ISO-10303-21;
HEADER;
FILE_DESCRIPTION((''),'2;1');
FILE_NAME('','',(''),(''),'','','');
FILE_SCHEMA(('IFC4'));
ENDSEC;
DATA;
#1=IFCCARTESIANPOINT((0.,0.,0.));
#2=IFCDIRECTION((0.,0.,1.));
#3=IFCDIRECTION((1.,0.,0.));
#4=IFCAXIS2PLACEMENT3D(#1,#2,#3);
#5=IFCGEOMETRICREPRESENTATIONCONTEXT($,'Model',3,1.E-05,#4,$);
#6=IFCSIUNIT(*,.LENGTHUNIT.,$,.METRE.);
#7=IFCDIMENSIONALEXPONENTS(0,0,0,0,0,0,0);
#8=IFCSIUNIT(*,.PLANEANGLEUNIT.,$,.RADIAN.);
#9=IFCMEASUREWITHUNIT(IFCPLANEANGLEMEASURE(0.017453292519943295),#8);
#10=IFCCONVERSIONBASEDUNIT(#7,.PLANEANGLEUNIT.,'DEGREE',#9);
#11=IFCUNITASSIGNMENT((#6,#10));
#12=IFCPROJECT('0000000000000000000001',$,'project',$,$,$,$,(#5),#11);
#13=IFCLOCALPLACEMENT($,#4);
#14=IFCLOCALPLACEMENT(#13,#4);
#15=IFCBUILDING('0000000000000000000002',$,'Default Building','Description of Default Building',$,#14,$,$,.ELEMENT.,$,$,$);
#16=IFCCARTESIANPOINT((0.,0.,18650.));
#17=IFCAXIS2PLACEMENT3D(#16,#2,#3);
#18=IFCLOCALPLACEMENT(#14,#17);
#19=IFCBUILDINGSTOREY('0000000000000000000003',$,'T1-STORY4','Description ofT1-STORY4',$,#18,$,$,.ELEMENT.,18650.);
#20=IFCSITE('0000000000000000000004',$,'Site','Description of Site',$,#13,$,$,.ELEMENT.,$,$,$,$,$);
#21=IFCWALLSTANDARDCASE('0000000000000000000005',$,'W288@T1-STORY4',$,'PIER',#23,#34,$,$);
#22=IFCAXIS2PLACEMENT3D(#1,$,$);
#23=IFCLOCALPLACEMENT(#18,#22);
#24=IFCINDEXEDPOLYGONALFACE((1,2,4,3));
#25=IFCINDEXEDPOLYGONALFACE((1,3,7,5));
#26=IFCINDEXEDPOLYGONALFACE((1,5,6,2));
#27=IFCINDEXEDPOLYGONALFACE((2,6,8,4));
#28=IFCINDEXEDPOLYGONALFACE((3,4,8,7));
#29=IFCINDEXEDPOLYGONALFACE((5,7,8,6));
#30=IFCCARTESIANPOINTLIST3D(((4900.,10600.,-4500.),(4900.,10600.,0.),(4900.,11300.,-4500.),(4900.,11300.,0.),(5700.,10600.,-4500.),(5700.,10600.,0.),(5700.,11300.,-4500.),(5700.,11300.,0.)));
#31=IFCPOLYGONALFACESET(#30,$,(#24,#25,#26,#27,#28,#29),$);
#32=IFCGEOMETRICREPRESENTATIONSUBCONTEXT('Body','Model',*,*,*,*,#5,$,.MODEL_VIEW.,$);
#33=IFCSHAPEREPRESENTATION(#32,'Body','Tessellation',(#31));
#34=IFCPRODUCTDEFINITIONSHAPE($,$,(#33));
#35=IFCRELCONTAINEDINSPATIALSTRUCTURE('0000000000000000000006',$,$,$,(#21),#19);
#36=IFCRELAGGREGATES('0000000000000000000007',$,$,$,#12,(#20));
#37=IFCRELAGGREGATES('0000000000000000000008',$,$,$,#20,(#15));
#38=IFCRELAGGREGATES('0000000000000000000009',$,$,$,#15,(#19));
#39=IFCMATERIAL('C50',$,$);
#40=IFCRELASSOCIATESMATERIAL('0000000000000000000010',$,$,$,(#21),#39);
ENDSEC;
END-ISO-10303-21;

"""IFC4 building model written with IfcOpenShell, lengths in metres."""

from ifc_helpers import new_model, entity, si_unit, converted_unit, frame, origin_with_axes, place, context, subcontext, project, spatial, indexed_curve, outline, extrude, material, element, save


model = new_model("IFC4")

# Units and contexts
model_context = context("Model", 3, precision=1e-05, world=origin_with_axes())
body_context = subcontext(model_context, "Body", "Model", "MODEL_VIEW")
ifc_project = project(units=[si_unit("LENGTHUNIT", "METRE"), converted_unit("PLANEANGLEUNIT", "DEGREE", entity("IfcPlaneAngleMeasure", 0.017453292519943295), si_unit("PLANEANGLEUNIT", "RADIAN"), dimensions=[0, 0, 0, 0, 0, 0, 0])], contexts=[model_context])

# Site, building, storey
site_placement = place(None, origin_with_axes())
site = spatial("IfcSite", under=ifc_project, at=site_placement, Name="Site", Description="Description of Site", CompositionType="ELEMENT")
building_placement = place(site_placement, origin_with_axes())
building = spatial("IfcBuilding", under=site, at=building_placement, Name="Default Building", Description="Description of Default Building", CompositionType="ELEMENT")
storey_placement = place(building_placement, frame((0.0, 0.0, 18650.0), z_axis=(0.0, 0.0, 1.0), x_axis=(1.0, 0.0, 0.0)))
storey = spatial("IfcBuildingStorey", under=building, at=storey_placement, Name="T1-STORY4", Description="Description ofT1-STORY4", CompositionType="ELEMENT", Elevation=18650.0)

# Shared definitions
ifc_material_1 = material(Name="C50")

# Wall
wall_1_placement = place(storey_placement, frame((5300.0, 10600.0, -4500.0), z_axis=(0.0, 0.0, 1.0), x_axis=(0.0, 1.0, 0.0)))
element("IfcWallStandardCase", 1, at=wall_1_placement, inside=storey, material=ifc_material_1, Name="W288@T1-STORY4", ObjectType="PIER", context=body_context, shape_type="SweptSolid", body=[
    extrude(outline(indexed_curve([(0.0, -400.0), (0.0, 400.0), (700.0, 400.0), (700.0, -400.0), (0.0, -400.0)], self_intersect=False)), origin_with_axes(), (0.0, 0.0, 1.0), 4500.0),
])

save(model, "model.ifc")
